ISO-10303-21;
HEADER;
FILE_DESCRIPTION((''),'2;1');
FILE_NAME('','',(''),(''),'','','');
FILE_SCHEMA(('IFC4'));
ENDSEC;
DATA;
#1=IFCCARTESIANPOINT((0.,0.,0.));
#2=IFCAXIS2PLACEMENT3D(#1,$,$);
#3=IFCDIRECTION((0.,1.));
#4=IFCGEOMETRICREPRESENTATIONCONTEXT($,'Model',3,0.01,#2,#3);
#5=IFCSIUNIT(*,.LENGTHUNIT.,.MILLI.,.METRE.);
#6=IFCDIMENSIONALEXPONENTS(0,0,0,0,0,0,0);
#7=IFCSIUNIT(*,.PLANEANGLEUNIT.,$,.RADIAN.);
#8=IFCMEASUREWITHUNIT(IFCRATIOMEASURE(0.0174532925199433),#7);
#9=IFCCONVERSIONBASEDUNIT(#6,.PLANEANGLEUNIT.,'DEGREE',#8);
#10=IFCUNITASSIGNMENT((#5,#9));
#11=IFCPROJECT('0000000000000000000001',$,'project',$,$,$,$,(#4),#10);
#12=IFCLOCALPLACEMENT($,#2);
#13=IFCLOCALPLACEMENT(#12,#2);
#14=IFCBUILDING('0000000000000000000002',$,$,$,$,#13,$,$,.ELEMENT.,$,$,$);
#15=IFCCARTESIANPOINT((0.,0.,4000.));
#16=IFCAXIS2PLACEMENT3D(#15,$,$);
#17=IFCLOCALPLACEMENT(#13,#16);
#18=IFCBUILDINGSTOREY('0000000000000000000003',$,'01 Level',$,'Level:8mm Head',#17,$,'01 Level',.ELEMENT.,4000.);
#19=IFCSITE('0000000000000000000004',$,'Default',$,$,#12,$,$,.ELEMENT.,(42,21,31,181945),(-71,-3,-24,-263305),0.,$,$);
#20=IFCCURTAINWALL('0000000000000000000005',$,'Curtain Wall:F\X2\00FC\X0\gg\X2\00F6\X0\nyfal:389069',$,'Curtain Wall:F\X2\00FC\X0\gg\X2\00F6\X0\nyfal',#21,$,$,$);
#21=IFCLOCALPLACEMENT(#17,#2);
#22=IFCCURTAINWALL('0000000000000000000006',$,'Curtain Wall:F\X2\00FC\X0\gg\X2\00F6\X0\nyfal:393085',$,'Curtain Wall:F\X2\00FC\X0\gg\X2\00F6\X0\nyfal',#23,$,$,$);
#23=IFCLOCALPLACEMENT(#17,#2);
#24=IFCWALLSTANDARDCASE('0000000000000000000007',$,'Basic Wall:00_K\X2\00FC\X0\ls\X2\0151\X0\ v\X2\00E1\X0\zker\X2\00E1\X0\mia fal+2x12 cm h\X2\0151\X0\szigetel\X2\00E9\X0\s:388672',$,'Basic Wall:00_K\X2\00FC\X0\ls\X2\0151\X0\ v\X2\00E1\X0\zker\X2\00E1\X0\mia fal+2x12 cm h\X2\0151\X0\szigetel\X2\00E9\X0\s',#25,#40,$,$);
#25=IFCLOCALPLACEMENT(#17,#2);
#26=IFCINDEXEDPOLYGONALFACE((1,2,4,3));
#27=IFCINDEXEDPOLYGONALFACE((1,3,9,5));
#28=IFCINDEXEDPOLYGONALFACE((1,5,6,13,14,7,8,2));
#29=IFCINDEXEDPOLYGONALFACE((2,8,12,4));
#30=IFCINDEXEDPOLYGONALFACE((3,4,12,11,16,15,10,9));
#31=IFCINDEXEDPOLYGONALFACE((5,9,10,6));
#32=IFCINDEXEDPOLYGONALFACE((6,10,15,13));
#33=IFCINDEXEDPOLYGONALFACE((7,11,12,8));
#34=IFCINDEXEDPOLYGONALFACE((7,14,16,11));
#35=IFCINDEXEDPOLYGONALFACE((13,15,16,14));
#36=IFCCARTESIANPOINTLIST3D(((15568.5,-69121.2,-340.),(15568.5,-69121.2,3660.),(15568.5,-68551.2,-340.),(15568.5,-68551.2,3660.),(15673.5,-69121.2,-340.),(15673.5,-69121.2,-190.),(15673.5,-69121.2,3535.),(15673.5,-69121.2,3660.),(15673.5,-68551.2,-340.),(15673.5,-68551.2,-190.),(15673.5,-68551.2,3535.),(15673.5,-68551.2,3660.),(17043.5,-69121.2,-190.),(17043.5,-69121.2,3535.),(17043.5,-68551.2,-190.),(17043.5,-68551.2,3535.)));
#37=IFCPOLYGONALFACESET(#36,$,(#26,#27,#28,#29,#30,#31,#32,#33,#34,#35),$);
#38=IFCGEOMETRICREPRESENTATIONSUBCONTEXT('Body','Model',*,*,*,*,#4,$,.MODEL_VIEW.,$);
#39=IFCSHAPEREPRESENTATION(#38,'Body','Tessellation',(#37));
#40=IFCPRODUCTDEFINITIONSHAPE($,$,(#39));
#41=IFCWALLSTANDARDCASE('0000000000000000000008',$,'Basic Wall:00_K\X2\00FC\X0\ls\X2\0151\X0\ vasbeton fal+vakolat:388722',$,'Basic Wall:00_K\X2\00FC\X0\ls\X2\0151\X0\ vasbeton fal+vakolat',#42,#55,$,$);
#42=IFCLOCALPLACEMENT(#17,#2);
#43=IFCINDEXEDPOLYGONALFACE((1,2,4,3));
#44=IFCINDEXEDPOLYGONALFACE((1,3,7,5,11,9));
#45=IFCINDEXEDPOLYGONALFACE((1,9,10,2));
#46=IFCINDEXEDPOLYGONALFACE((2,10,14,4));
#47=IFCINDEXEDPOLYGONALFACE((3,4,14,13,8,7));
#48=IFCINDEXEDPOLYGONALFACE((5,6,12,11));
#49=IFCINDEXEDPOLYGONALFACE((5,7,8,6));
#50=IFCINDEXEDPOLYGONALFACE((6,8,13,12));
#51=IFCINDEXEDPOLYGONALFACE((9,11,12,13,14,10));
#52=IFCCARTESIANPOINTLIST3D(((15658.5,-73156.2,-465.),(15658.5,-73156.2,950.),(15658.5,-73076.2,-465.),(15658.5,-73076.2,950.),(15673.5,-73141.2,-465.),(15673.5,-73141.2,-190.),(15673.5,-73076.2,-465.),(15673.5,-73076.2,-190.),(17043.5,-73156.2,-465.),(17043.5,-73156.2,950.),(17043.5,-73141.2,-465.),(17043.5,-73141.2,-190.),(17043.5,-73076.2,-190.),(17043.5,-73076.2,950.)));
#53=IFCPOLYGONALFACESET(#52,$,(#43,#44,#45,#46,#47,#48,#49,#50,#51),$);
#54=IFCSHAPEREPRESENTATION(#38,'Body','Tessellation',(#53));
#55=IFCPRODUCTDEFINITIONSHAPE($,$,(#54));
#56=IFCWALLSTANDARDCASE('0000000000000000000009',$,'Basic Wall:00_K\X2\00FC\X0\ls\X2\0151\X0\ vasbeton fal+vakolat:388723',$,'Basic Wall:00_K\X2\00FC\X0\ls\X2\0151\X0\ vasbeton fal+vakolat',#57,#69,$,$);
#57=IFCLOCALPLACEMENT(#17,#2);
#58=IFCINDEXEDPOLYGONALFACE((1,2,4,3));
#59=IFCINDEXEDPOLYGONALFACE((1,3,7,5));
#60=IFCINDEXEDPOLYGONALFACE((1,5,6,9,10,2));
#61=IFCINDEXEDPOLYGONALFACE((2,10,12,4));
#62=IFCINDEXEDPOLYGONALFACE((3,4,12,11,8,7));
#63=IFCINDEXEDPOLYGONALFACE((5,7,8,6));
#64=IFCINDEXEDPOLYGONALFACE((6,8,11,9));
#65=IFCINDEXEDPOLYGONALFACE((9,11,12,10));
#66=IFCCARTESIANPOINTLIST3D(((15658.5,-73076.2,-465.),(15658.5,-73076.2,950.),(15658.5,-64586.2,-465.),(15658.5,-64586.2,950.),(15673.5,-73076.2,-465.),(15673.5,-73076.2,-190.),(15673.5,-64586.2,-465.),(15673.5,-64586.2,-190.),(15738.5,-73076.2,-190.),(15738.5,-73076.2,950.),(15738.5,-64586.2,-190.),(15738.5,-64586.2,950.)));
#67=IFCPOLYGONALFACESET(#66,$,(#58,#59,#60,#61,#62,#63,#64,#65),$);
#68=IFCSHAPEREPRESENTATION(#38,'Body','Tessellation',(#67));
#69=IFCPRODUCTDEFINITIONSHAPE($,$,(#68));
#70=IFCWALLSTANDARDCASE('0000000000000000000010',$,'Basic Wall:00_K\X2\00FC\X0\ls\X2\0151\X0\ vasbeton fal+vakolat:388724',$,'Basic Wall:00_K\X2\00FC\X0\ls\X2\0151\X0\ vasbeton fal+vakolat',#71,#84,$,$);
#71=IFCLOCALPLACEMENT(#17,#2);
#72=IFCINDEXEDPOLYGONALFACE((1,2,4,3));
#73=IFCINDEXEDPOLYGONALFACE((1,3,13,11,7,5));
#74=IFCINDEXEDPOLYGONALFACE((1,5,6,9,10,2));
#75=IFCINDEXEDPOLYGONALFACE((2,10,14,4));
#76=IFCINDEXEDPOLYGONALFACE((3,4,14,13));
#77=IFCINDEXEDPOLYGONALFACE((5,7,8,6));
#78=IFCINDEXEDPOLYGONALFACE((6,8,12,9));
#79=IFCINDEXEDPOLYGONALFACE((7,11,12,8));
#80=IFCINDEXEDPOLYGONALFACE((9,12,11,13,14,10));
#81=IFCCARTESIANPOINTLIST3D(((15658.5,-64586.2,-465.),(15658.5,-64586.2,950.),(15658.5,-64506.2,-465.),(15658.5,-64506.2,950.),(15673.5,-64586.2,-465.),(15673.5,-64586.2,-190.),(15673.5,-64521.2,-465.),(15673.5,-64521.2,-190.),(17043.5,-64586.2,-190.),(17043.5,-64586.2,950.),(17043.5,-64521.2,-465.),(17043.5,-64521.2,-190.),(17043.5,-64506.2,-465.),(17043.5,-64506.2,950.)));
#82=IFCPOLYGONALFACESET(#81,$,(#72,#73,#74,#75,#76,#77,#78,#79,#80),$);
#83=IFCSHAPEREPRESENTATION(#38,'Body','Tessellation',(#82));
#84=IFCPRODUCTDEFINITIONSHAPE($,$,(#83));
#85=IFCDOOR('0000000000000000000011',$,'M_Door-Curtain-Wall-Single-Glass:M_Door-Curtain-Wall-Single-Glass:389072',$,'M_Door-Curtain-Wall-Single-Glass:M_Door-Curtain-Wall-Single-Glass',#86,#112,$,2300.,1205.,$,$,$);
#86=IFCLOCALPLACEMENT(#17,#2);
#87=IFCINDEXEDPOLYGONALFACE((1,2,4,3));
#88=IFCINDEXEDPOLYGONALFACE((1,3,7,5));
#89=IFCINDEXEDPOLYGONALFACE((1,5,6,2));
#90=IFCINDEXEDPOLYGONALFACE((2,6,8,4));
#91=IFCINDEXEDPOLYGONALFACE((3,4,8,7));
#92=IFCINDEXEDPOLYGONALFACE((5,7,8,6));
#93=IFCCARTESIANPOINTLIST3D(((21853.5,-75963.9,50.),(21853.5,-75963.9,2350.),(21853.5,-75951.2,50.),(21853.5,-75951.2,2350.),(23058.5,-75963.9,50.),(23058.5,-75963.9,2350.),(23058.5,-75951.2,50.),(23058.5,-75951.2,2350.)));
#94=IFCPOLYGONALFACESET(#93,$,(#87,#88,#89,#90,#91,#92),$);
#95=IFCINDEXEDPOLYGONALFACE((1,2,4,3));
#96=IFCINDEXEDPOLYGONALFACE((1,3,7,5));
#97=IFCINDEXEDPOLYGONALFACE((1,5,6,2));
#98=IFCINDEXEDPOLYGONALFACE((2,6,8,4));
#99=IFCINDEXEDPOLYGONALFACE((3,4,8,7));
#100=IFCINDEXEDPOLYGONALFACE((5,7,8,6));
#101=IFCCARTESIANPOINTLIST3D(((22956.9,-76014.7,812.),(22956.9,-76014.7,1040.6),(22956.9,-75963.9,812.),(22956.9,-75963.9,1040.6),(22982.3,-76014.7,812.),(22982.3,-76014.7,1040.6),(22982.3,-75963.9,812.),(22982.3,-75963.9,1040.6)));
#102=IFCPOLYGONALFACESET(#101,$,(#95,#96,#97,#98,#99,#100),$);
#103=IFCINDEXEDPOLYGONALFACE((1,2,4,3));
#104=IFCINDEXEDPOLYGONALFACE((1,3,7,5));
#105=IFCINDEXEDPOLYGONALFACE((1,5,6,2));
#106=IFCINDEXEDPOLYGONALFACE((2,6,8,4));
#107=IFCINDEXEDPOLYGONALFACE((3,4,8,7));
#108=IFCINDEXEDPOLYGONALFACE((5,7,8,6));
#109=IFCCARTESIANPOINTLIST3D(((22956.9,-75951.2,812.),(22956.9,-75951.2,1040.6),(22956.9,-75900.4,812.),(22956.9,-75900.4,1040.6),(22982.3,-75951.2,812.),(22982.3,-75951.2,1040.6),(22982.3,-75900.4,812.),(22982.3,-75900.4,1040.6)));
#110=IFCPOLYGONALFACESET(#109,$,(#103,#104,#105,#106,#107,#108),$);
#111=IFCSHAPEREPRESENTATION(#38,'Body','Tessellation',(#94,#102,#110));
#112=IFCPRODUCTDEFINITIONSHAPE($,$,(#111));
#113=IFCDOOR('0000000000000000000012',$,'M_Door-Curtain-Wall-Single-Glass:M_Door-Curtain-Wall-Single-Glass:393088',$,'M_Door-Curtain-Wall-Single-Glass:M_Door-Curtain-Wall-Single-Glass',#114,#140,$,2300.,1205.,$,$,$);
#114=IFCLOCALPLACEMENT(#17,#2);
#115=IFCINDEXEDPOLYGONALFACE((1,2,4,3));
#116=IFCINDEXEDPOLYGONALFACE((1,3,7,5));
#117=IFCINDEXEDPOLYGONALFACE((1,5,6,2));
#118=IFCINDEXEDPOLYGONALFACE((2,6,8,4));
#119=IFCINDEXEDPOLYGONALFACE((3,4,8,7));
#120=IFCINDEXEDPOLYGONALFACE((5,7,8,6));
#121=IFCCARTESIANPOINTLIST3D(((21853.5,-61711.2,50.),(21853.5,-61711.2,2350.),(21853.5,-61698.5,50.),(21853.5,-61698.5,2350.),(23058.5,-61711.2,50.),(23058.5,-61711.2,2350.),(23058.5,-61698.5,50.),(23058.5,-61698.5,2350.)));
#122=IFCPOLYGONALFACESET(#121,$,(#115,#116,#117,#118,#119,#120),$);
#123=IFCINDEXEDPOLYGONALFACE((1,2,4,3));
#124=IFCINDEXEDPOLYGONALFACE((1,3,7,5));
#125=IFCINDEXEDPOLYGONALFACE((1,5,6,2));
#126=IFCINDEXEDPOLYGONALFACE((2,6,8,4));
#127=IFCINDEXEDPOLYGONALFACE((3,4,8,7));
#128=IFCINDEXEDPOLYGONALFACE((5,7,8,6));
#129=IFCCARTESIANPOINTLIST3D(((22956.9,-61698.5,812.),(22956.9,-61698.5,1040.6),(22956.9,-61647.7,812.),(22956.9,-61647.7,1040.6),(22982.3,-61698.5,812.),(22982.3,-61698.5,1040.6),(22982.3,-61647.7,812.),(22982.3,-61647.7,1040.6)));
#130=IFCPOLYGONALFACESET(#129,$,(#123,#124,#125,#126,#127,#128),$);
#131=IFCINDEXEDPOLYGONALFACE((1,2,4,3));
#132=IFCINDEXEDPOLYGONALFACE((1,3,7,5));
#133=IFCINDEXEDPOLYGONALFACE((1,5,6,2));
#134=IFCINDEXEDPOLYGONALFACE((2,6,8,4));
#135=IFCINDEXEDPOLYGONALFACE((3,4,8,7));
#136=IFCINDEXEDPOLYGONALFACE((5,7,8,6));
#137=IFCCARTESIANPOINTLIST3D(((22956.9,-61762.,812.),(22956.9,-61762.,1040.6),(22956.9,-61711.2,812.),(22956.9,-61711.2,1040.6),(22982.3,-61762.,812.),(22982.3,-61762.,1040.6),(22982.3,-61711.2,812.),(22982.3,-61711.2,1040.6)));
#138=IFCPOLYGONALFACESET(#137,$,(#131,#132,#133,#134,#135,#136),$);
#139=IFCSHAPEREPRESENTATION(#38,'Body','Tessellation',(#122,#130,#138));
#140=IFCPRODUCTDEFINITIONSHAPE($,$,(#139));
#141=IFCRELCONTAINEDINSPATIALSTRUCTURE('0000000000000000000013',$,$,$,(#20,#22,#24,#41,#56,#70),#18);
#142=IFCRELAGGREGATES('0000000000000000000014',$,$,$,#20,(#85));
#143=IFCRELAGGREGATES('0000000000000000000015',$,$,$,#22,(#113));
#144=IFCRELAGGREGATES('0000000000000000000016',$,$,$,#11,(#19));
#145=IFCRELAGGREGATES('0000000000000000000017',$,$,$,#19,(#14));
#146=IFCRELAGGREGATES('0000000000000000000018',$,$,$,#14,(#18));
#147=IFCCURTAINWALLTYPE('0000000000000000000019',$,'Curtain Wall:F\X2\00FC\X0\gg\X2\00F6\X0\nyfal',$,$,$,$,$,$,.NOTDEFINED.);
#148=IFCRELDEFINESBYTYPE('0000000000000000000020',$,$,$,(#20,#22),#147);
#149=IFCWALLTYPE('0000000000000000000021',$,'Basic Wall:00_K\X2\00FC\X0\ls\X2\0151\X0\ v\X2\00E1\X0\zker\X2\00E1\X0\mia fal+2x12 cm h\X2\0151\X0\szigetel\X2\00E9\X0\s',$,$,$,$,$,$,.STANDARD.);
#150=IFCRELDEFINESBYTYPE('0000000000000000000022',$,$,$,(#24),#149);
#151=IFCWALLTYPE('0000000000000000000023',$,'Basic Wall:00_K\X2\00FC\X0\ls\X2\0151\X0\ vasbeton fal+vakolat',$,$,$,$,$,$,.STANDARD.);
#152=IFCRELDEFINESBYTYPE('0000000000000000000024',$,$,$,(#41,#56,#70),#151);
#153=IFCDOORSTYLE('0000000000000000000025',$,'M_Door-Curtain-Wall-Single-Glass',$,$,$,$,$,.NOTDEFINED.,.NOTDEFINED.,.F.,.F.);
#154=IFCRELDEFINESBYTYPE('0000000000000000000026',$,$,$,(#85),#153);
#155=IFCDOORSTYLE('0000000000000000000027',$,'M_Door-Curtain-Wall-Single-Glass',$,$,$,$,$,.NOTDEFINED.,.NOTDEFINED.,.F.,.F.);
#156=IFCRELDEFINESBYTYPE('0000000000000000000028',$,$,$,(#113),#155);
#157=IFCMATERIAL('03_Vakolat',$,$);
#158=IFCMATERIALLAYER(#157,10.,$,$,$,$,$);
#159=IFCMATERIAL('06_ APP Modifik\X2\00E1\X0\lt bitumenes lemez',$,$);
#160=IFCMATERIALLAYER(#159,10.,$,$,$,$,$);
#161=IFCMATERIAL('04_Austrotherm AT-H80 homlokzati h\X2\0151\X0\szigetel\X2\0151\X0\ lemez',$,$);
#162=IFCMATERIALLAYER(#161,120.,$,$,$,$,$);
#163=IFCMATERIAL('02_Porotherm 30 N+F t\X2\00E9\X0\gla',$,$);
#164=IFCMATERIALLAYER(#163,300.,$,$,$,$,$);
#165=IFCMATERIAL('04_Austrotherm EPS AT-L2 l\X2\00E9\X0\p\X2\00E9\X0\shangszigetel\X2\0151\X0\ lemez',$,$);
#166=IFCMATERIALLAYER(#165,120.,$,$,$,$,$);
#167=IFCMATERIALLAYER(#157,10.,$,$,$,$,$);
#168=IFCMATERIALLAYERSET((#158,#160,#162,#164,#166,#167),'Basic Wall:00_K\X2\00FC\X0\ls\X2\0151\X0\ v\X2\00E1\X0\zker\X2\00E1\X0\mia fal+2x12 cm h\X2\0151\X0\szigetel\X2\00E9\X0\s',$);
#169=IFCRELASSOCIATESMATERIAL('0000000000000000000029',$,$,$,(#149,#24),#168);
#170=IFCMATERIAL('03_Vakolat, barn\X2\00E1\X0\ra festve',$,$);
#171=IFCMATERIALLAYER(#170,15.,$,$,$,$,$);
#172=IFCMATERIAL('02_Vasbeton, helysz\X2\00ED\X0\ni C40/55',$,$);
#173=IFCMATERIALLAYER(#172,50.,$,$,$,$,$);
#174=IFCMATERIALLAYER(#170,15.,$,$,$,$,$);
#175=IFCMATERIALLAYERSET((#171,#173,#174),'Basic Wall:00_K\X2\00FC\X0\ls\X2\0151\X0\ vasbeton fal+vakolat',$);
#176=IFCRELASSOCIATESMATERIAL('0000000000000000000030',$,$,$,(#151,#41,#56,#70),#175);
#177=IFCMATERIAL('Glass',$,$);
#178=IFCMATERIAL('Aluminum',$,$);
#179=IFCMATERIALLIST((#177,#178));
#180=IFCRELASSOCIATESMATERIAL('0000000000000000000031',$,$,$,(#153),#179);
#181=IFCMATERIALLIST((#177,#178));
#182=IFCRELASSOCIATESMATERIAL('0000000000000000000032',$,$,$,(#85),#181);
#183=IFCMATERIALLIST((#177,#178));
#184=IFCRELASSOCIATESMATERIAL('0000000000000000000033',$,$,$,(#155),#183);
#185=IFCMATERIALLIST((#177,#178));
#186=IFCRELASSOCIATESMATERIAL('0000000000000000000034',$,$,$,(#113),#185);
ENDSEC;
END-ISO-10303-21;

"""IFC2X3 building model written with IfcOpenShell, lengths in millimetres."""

from ifc_helpers import new_model, entity, si_unit, converted_unit, direction, frame, frame_2d, origin, origin_2d_with_axis, place, context, subcontext, project, spatial, polyline, rectangle, extrude, clip, bounded_halfspace, source, transform, mapped, material, material_list, layer, layer_set, layer_usage, type_object, type_shapes, element, aggregate, save


model = new_model("IFC2X3")

# Units and contexts
model_context = context("Model", 3, precision=0.01, world=origin(), true_north=direction((0.0, 1.0)))
body_context = subcontext(model_context, "Body", "Model", "MODEL_VIEW")
ifc_project = project(units=[si_unit("LENGTHUNIT", "METRE", prefix="MILLI"), converted_unit("PLANEANGLEUNIT", "DEGREE", entity("IfcRatioMeasure", 0.0174532925199433), si_unit("PLANEANGLEUNIT", "RADIAN"), dimensions=[0, 0, 0, 0, 0, 0, 0])], contexts=[model_context])

# Site, building, storey
site_placement = place(None, origin())
site = spatial("IfcSite", under=ifc_project, at=site_placement, Name="Default", CompositionType="ELEMENT", RefLatitude=(42, 21, 31, 181945), RefLongitude=(-71, -3, -24, -263305), RefElevation=0.0)
building_placement = place(site_placement, origin())
building = spatial("IfcBuilding", under=site, at=building_placement, CompositionType="ELEMENT")
storey_placement = place(building_placement, frame((0.0, 0.0, 4000.0)))
storey = spatial("IfcBuildingStorey", under=building, at=storey_placement, Name="01 Level", ObjectType="Level:8mm Head", LongName="01 Level", CompositionType="ELEMENT", Elevation=4000.0)

# Curtain walls
curtain_wall_type = type_object("IfcCurtainWallType", Name="Curtain Wall:Függönyfal", PredefinedType="NOTDEFINED")
curtain_wall_1_placement = place(storey_placement, frame((0.0, 0.0, -4000.0)))
curtain_wall_1 = element("IfcCurtainWall", 1, at=curtain_wall_1_placement, inside=storey, type_object=curtain_wall_type, Name="Curtain Wall:Függönyfal:389069", ObjectType="Curtain Wall:Függönyfal")
curtain_wall_2_placement = place(storey_placement, frame((0.0, 0.0, -4000.0)))
curtain_wall_2 = element("IfcCurtainWall", 2, at=curtain_wall_2_placement, inside=storey, type_object=curtain_wall_type, Name="Curtain Wall:Függönyfal:393085", ObjectType="Curtain Wall:Függönyfal")

# Shared definitions
ifc_material_1 = material(Name="03_Vakolat")
ifc_material_2 = material(Name="04_Austrotherm AT-H80 homlokzati hőszigetelő lemez")
ifc_material_3 = material(Name="02_Porotherm 30 N+F tégla")

# Walls
ifc_layer_1 = layer(ifc_material_1, 10.0)
ifc_material_4 = material(Name="06_ APP Modifikált bitumenes lemez")
ifc_layer_2 = layer(ifc_material_4, 10.0)
ifc_layer_3 = layer(ifc_material_2, 120.0)
ifc_layer_4 = layer(ifc_material_3, 300.0)
ifc_material_5 = material(Name="04_Austrotherm EPS AT-L2 lépéshangszigetelő lemez")
ifc_layer_5 = layer(ifc_material_5, 120.0)
ifc_layer_6 = layer(ifc_material_1, 10.0)
ifc_layer_set_1 = layer_set([ifc_layer_1, ifc_layer_2, ifc_layer_3, ifc_layer_4, ifc_layer_5, ifc_layer_6], Name="Basic Wall:00_Külső vázkerámia fal+2x12 cm hőszigetelés")
ifc_layer_usage_1 = layer_usage(ifc_layer_set_1, "AXIS2", "NEGATIVE", 285.0)
wall_type_1 = type_object("IfcWallType", Name="Basic Wall:00_Külső vázkerámia fal+2x12 cm hőszigetelés", PredefinedType="STANDARD", material=ifc_layer_set_1)
wall_1_placement = place(storey_placement, frame((17043.5, -68836.2, -340.0), z_axis=(0.0, 0.0, 1.0), x_axis=(-1.0, 0.0, 0.0)))
element("IfcWallStandardCase", 3, at=wall_1_placement, inside=storey, type_object=wall_type_1, material=ifc_layer_usage_1, Name="Basic Wall:00_Külső vázkerámia fal+2x12 cm hőszigetelés:388672", ObjectType="Basic Wall:00_Külső vázkerámia fal+2x12 cm hőszigetelés", context=body_context, shape_type="Clipping", body=[
    clip(clip(clip(clip(extrude(rectangle(XDim=1475.0, YDim=570.0, at=frame_2d((737.5, 0.0), x_axis=(-1.0, 0.0))), origin(), (0.0, 0.0, 1.0), 4000.0), bounded_halfspace(frame((1370.0, 285.0, 150.0)), True, frame((1370.0, 285.0, 150.0)), polyline([(0.0, 0.0), (-1370.0, 0.0), (-1370.0, -570.0), (0.0, -570.0), (0.0, 0.0)]))), bounded_halfspace(frame((1370.0, -285.0, 150.0), z_axis=(1.0, 0.0, 0.0), x_axis=(0.0, 0.0, 1.0)), True, frame((1370.0, -285.0, 150.0), z_axis=(1.0, 0.0, 0.0), x_axis=(0.0, 0.0, 1.0)), polyline([(0.0, 0.0), (-150.0, 0.0), (-150.0, -570.0), (0.0, -570.0), (0.0, 0.0)]))), bounded_halfspace(frame((1370.0, -285.0, 3875.0), z_axis=(0.0, 0.0, -1.0), x_axis=(-1.0, 0.0, 0.0)), True, frame((1370.0, -285.0, 3875.0), z_axis=(0.0, 0.0, -1.0), x_axis=(-1.0, 0.0, 0.0)), polyline([(0.0, 0.0), (1370.0, 0.0), (1370.0, 570.0), (0.0, 570.0), (0.0, 0.0)]))), bounded_halfspace(frame((1370.0, 285.0, 3875.0), z_axis=(1.0, 0.0, 0.0), x_axis=(0.0, 0.0, 1.0)), True, frame((1370.0, 285.0, 3875.0), z_axis=(1.0, 0.0, 0.0), x_axis=(0.0, 0.0, 1.0)), polyline([(0.0, 0.0), (125.0, 0.0), (125.0, 570.0), (0.0, 570.0), (0.0, 0.0)]))),
])
ifc_material_6 = material(Name="03_Vakolat, barnára festve")
ifc_layer_7 = layer(ifc_material_6, 15.0)
ifc_material_7 = material(Name="02_Vasbeton, helyszíni C40/55")
ifc_layer_8 = layer(ifc_material_7, 50.0)
ifc_layer_9 = layer(ifc_material_6, 15.0)
ifc_layer_set_2 = layer_set([ifc_layer_7, ifc_layer_8, ifc_layer_9], Name="Basic Wall:00_Külső vasbeton fal+vakolat")
ifc_layer_usage_2 = layer_usage(ifc_layer_set_2, "AXIS2", "NEGATIVE", 40.0)
wall_type_2 = type_object("IfcWallType", Name="Basic Wall:00_Külső vasbeton fal+vakolat", PredefinedType="STANDARD", material=ifc_layer_set_2)
wall_2_placement = place(storey_placement, frame((17043.5, -73116.2, -465.0), z_axis=(0.0, 0.0, 1.0), x_axis=(-1.0, 0.0, 0.0)))
element("IfcWallStandardCase", 4, at=wall_2_placement, inside=storey, type_object=wall_type_2, material=ifc_layer_usage_2, Name="Basic Wall:00_Külső vasbeton fal+vakolat:388722", ObjectType="Basic Wall:00_Külső vasbeton fal+vakolat", context=body_context, shape_type="Clipping", body=[
    clip(clip(clip(extrude(rectangle(XDim=1385.0, YDim=80.0, at=frame_2d((692.5, 0.0), x_axis=(-1.0, 0.0))), origin(), (0.0, 0.0, 1.0), 1415.0), bounded_halfspace(frame((1370.0, 25.0, 0.0), z_axis=(1.0, 0.0, 0.0), x_axis=(0.0, 0.0, 1.0)), True, frame((1370.0, 25.0, 0.0), z_axis=(1.0, 0.0, 0.0), x_axis=(0.0, 0.0, 1.0)), polyline([(0.0, 0.0), (125.0, 0.0), (275.0, 0.0), (275.0, 65.0), (0.0, 65.0), (0.0, 0.0)]))), bounded_halfspace(frame((1370.0, 25.0, 0.0), z_axis=(0.0, 1.0, 0.0), x_axis=(0.0, 0.0, 1.0)), True, frame((1370.0, 25.0, 0.0), z_axis=(0.0, 1.0, 0.0), x_axis=(0.0, 0.0, 1.0)), polyline([(0.0, 0.0), (0.0, -1370.0), (125.0, -1370.0), (275.0, -1370.0), (275.0, 0.0), (125.0, 0.0), (0.0, 0.0)]))), bounded_halfspace(frame((1370.0, 25.0, 275.0)), True, frame((1370.0, 25.0, 275.0)), polyline([(0.0, 0.0), (-1370.0, 0.0), (-1370.0, -65.0), (-65.0, -65.0), (0.0, -65.0), (0.0, 0.0)]))),
])
ifc_layer_usage_3 = layer_usage(ifc_layer_set_2, "AXIS2", "NEGATIVE", 40.0)
wall_3_placement = place(storey_placement, frame((15698.5, -73076.2, -465.0), z_axis=(0.0, 0.0, 1.0), x_axis=(0.0, 1.0, 0.0)))
element("IfcWallStandardCase", 5, at=wall_3_placement, inside=storey, type_object=wall_type_2, material=ifc_layer_usage_3, Name="Basic Wall:00_Külső vasbeton fal+vakolat:388723", ObjectType="Basic Wall:00_Külső vasbeton fal+vakolat", context=body_context, shape_type="Clipping", body=[
    clip(clip(extrude(rectangle(XDim=8490.0, YDim=80.0, at=frame_2d((4245.0, 0.0), x_axis=(-1.0, 0.0))), origin(), (0.0, 0.0, 1.0), 1415.0), bounded_halfspace(frame((0.0, 25.0, 0.0), z_axis=(0.0, 1.0, 0.0), x_axis=(0.0, 0.0, 1.0)), True, frame((0.0, 25.0, 0.0), z_axis=(0.0, 1.0, 0.0), x_axis=(0.0, 0.0, 1.0)), polyline([(0.0, 0.0), (125.0, 0.0), (275.0, 0.0), (275.0, 8490.0), (125.0, 8490.0), (0.0, 8490.0), (0.0, 0.0)]))), bounded_halfspace(frame((0.0, 25.0, 275.0), z_axis=(0.0, 0.0, 1.0), x_axis=(0.0, 1.0, 0.0)), True, frame((0.0, 25.0, 275.0), z_axis=(0.0, 0.0, 1.0), x_axis=(0.0, 1.0, 0.0)), polyline([(0.0, 0.0), (-65.0, 0.0), (-65.0, -8490.0), (0.0, -8490.0), (0.0, 0.0)]))),
])
ifc_layer_usage_4 = layer_usage(ifc_layer_set_2, "AXIS2", "POSITIVE", -40.0)
wall_4_placement = place(storey_placement, frame((17043.5, -64546.2, -465.0), z_axis=(0.0, 0.0, 1.0), x_axis=(-1.0, 0.0, 0.0)))
element("IfcWallStandardCase", 6, at=wall_4_placement, inside=storey, type_object=wall_type_2, material=ifc_layer_usage_4, Name="Basic Wall:00_Külső vasbeton fal+vakolat:388724", ObjectType="Basic Wall:00_Külső vasbeton fal+vakolat", context=body_context, shape_type="Clipping", body=[
    clip(clip(clip(extrude(rectangle(XDim=1385.0, YDim=80.0, at=frame_2d((692.5, 0.0), x_axis=(-1.0, 0.0))), origin(), (0.0, 0.0, 1.0), 1415.0), bounded_halfspace(frame((1370.0, -25.0, 275.0), z_axis=(1.0, 0.0, 0.0), x_axis=(0.0, 0.0, 1.0)), True, frame((1370.0, -25.0, 275.0), z_axis=(1.0, 0.0, 0.0), x_axis=(0.0, 0.0, 1.0)), polyline([(0.0, 0.0), (-150.0, 0.0), (-275.0, 0.0), (-275.0, -65.0), (0.0, -65.0), (0.0, 0.0)]))), bounded_halfspace(frame((1370.0, -25.0, 275.0), z_axis=(0.0, -1.0, 0.0), x_axis=(0.0, 0.0, 1.0)), True, frame((1370.0, -25.0, 275.0), z_axis=(0.0, -1.0, 0.0), x_axis=(0.0, 0.0, 1.0)), polyline([(0.0, 0.0), (0.0, 1370.0), (-150.0, 1370.0), (-275.0, 1370.0), (-275.0, 0.0), (-150.0, 0.0), (0.0, 0.0)]))), bounded_halfspace(frame((1370.0, 40.0, 275.0)), True, frame((1370.0, 40.0, 275.0)), polyline([(0.0, 0.0), (-65.0, 0.0), (-1370.0, 0.0), (-1370.0, -65.0), (0.0, -65.0), (0.0, 0.0)]))),
])

# Doors
ifc_material_8 = material(Name="Glass")
ifc_material_9 = material(Name="Aluminum")
ifc_material_list_1 = material_list([ifc_material_8, ifc_material_9])
ifc_material_list_2 = material_list([ifc_material_8, ifc_material_9])
door_style_1 = type_object("IfcDoorStyle", Name="M_Door-Curtain-Wall-Single-Glass", ConstructionType="NOTDEFINED", OperationType="NOTDEFINED", ParameterTakesPrecedence=False, Sizeable=False, material=ifc_material_list_2)
shared_shape_1 = source(origin(), body_context, "Body", "SweptSolid", [
    extrude(rectangle(XDim=12.7, YDim=1205.0, at=origin_2d_with_axis()), frame((0.0, 6.3, 0.0), z_axis=(0.0, 0.0, 1.0), x_axis=(0.0, 1.0, 0.0)), (0.0, 0.0, 1.0), 2300.0),
    extrude(rectangle(XDim=25.4, YDim=50.8, at=frame_2d((0.0, 0.0), x_axis=(1.0, 0.0))), frame((-513.6, 38.1, 762.0), z_axis=(0.0, 0.0, 1.0), x_axis=(-1.0, 0.0, 0.0)), (0.0, 0.0, 1.0), 228.6),
    extrude(rectangle(XDim=25.4, YDim=50.8, at=frame_2d((0.0, 0.0), x_axis=(1.0, 0.0))), frame((-513.6, -25.4, 762.0)), (0.0, 0.0, 1.0), 228.6),
])
type_shapes(door_style_1, [shared_shape_1])
door_1_placement = place(curtain_wall_1_placement, frame((22456.0, -75951.2, 4050.0), z_axis=(0.0, 0.0, 1.0), x_axis=(-1.0, 0.0, 0.0)))
door_1 = element("IfcDoor", 7, at=door_1_placement, type_object=door_style_1, material=ifc_material_list_1, Name="M_Door-Curtain-Wall-Single-Glass:M_Door-Curtain-Wall-Single-Glass:389072", ObjectType="M_Door-Curtain-Wall-Single-Glass:M_Door-Curtain-Wall-Single-Glass", OverallHeight=2300.0, OverallWidth=1205.0, context=body_context, shape_type="MappedRepresentation", body=[
    mapped(shared_shape_1, transform((0.0, 0.0, 0.0), scale=1.0)),
])
aggregate(curtain_wall_1, [door_1])
ifc_material_list_3 = material_list([ifc_material_8, ifc_material_9])
ifc_material_list_4 = material_list([ifc_material_8, ifc_material_9])
door_style_2 = type_object("IfcDoorStyle", Name="M_Door-Curtain-Wall-Single-Glass", ConstructionType="NOTDEFINED", OperationType="NOTDEFINED", ParameterTakesPrecedence=False, Sizeable=False, material=ifc_material_list_4)
shared_shape_2 = source(origin(), body_context, "Body", "SweptSolid", [
    extrude(rectangle(XDim=1205.0, YDim=12.7, at=origin_2d_with_axis()), frame((0.0, -6.3, 0.0), z_axis=(0.0, 0.0, 1.0), x_axis=(-1.0, 0.0, 0.0)), (0.0, 0.0, 1.0), 2300.0),
    extrude(rectangle(XDim=50.8, YDim=25.4, at=frame_2d((0.0, 0.0), x_axis=(1.0, 0.0))), frame((-513.6, -38.1, 762.0), z_axis=(0.0, 0.0, 1.0), x_axis=(0.0, 1.0, 0.0)), (0.0, 0.0, 1.0), 228.6),
    extrude(rectangle(XDim=50.8, YDim=25.4, at=frame_2d((0.0, 0.0), x_axis=(1.0, 0.0))), frame((-513.6, 25.4, 762.0), z_axis=(0.0, 0.0, 1.0), x_axis=(0.0, -1.0, 0.0)), (0.0, 0.0, 1.0), 228.6),
])
type_shapes(door_style_2, [shared_shape_2])
door_2_placement = place(curtain_wall_2_placement, frame((22456.0, -61711.2, 4050.0), z_axis=(0.0, 0.0, 1.0), x_axis=(-1.0, 0.0, 0.0)))
door_2 = element("IfcDoor", 8, at=door_2_placement, type_object=door_style_2, material=ifc_material_list_3, Name="M_Door-Curtain-Wall-Single-Glass:M_Door-Curtain-Wall-Single-Glass:393088", ObjectType="M_Door-Curtain-Wall-Single-Glass:M_Door-Curtain-Wall-Single-Glass", OverallHeight=2300.0, OverallWidth=1205.0, context=body_context, shape_type="MappedRepresentation", body=[
    mapped(shared_shape_2, transform((0.0, 0.0, 0.0), scale=1.0)),
])
aggregate(curtain_wall_2, [door_2])

save(model, "model.ifc")
